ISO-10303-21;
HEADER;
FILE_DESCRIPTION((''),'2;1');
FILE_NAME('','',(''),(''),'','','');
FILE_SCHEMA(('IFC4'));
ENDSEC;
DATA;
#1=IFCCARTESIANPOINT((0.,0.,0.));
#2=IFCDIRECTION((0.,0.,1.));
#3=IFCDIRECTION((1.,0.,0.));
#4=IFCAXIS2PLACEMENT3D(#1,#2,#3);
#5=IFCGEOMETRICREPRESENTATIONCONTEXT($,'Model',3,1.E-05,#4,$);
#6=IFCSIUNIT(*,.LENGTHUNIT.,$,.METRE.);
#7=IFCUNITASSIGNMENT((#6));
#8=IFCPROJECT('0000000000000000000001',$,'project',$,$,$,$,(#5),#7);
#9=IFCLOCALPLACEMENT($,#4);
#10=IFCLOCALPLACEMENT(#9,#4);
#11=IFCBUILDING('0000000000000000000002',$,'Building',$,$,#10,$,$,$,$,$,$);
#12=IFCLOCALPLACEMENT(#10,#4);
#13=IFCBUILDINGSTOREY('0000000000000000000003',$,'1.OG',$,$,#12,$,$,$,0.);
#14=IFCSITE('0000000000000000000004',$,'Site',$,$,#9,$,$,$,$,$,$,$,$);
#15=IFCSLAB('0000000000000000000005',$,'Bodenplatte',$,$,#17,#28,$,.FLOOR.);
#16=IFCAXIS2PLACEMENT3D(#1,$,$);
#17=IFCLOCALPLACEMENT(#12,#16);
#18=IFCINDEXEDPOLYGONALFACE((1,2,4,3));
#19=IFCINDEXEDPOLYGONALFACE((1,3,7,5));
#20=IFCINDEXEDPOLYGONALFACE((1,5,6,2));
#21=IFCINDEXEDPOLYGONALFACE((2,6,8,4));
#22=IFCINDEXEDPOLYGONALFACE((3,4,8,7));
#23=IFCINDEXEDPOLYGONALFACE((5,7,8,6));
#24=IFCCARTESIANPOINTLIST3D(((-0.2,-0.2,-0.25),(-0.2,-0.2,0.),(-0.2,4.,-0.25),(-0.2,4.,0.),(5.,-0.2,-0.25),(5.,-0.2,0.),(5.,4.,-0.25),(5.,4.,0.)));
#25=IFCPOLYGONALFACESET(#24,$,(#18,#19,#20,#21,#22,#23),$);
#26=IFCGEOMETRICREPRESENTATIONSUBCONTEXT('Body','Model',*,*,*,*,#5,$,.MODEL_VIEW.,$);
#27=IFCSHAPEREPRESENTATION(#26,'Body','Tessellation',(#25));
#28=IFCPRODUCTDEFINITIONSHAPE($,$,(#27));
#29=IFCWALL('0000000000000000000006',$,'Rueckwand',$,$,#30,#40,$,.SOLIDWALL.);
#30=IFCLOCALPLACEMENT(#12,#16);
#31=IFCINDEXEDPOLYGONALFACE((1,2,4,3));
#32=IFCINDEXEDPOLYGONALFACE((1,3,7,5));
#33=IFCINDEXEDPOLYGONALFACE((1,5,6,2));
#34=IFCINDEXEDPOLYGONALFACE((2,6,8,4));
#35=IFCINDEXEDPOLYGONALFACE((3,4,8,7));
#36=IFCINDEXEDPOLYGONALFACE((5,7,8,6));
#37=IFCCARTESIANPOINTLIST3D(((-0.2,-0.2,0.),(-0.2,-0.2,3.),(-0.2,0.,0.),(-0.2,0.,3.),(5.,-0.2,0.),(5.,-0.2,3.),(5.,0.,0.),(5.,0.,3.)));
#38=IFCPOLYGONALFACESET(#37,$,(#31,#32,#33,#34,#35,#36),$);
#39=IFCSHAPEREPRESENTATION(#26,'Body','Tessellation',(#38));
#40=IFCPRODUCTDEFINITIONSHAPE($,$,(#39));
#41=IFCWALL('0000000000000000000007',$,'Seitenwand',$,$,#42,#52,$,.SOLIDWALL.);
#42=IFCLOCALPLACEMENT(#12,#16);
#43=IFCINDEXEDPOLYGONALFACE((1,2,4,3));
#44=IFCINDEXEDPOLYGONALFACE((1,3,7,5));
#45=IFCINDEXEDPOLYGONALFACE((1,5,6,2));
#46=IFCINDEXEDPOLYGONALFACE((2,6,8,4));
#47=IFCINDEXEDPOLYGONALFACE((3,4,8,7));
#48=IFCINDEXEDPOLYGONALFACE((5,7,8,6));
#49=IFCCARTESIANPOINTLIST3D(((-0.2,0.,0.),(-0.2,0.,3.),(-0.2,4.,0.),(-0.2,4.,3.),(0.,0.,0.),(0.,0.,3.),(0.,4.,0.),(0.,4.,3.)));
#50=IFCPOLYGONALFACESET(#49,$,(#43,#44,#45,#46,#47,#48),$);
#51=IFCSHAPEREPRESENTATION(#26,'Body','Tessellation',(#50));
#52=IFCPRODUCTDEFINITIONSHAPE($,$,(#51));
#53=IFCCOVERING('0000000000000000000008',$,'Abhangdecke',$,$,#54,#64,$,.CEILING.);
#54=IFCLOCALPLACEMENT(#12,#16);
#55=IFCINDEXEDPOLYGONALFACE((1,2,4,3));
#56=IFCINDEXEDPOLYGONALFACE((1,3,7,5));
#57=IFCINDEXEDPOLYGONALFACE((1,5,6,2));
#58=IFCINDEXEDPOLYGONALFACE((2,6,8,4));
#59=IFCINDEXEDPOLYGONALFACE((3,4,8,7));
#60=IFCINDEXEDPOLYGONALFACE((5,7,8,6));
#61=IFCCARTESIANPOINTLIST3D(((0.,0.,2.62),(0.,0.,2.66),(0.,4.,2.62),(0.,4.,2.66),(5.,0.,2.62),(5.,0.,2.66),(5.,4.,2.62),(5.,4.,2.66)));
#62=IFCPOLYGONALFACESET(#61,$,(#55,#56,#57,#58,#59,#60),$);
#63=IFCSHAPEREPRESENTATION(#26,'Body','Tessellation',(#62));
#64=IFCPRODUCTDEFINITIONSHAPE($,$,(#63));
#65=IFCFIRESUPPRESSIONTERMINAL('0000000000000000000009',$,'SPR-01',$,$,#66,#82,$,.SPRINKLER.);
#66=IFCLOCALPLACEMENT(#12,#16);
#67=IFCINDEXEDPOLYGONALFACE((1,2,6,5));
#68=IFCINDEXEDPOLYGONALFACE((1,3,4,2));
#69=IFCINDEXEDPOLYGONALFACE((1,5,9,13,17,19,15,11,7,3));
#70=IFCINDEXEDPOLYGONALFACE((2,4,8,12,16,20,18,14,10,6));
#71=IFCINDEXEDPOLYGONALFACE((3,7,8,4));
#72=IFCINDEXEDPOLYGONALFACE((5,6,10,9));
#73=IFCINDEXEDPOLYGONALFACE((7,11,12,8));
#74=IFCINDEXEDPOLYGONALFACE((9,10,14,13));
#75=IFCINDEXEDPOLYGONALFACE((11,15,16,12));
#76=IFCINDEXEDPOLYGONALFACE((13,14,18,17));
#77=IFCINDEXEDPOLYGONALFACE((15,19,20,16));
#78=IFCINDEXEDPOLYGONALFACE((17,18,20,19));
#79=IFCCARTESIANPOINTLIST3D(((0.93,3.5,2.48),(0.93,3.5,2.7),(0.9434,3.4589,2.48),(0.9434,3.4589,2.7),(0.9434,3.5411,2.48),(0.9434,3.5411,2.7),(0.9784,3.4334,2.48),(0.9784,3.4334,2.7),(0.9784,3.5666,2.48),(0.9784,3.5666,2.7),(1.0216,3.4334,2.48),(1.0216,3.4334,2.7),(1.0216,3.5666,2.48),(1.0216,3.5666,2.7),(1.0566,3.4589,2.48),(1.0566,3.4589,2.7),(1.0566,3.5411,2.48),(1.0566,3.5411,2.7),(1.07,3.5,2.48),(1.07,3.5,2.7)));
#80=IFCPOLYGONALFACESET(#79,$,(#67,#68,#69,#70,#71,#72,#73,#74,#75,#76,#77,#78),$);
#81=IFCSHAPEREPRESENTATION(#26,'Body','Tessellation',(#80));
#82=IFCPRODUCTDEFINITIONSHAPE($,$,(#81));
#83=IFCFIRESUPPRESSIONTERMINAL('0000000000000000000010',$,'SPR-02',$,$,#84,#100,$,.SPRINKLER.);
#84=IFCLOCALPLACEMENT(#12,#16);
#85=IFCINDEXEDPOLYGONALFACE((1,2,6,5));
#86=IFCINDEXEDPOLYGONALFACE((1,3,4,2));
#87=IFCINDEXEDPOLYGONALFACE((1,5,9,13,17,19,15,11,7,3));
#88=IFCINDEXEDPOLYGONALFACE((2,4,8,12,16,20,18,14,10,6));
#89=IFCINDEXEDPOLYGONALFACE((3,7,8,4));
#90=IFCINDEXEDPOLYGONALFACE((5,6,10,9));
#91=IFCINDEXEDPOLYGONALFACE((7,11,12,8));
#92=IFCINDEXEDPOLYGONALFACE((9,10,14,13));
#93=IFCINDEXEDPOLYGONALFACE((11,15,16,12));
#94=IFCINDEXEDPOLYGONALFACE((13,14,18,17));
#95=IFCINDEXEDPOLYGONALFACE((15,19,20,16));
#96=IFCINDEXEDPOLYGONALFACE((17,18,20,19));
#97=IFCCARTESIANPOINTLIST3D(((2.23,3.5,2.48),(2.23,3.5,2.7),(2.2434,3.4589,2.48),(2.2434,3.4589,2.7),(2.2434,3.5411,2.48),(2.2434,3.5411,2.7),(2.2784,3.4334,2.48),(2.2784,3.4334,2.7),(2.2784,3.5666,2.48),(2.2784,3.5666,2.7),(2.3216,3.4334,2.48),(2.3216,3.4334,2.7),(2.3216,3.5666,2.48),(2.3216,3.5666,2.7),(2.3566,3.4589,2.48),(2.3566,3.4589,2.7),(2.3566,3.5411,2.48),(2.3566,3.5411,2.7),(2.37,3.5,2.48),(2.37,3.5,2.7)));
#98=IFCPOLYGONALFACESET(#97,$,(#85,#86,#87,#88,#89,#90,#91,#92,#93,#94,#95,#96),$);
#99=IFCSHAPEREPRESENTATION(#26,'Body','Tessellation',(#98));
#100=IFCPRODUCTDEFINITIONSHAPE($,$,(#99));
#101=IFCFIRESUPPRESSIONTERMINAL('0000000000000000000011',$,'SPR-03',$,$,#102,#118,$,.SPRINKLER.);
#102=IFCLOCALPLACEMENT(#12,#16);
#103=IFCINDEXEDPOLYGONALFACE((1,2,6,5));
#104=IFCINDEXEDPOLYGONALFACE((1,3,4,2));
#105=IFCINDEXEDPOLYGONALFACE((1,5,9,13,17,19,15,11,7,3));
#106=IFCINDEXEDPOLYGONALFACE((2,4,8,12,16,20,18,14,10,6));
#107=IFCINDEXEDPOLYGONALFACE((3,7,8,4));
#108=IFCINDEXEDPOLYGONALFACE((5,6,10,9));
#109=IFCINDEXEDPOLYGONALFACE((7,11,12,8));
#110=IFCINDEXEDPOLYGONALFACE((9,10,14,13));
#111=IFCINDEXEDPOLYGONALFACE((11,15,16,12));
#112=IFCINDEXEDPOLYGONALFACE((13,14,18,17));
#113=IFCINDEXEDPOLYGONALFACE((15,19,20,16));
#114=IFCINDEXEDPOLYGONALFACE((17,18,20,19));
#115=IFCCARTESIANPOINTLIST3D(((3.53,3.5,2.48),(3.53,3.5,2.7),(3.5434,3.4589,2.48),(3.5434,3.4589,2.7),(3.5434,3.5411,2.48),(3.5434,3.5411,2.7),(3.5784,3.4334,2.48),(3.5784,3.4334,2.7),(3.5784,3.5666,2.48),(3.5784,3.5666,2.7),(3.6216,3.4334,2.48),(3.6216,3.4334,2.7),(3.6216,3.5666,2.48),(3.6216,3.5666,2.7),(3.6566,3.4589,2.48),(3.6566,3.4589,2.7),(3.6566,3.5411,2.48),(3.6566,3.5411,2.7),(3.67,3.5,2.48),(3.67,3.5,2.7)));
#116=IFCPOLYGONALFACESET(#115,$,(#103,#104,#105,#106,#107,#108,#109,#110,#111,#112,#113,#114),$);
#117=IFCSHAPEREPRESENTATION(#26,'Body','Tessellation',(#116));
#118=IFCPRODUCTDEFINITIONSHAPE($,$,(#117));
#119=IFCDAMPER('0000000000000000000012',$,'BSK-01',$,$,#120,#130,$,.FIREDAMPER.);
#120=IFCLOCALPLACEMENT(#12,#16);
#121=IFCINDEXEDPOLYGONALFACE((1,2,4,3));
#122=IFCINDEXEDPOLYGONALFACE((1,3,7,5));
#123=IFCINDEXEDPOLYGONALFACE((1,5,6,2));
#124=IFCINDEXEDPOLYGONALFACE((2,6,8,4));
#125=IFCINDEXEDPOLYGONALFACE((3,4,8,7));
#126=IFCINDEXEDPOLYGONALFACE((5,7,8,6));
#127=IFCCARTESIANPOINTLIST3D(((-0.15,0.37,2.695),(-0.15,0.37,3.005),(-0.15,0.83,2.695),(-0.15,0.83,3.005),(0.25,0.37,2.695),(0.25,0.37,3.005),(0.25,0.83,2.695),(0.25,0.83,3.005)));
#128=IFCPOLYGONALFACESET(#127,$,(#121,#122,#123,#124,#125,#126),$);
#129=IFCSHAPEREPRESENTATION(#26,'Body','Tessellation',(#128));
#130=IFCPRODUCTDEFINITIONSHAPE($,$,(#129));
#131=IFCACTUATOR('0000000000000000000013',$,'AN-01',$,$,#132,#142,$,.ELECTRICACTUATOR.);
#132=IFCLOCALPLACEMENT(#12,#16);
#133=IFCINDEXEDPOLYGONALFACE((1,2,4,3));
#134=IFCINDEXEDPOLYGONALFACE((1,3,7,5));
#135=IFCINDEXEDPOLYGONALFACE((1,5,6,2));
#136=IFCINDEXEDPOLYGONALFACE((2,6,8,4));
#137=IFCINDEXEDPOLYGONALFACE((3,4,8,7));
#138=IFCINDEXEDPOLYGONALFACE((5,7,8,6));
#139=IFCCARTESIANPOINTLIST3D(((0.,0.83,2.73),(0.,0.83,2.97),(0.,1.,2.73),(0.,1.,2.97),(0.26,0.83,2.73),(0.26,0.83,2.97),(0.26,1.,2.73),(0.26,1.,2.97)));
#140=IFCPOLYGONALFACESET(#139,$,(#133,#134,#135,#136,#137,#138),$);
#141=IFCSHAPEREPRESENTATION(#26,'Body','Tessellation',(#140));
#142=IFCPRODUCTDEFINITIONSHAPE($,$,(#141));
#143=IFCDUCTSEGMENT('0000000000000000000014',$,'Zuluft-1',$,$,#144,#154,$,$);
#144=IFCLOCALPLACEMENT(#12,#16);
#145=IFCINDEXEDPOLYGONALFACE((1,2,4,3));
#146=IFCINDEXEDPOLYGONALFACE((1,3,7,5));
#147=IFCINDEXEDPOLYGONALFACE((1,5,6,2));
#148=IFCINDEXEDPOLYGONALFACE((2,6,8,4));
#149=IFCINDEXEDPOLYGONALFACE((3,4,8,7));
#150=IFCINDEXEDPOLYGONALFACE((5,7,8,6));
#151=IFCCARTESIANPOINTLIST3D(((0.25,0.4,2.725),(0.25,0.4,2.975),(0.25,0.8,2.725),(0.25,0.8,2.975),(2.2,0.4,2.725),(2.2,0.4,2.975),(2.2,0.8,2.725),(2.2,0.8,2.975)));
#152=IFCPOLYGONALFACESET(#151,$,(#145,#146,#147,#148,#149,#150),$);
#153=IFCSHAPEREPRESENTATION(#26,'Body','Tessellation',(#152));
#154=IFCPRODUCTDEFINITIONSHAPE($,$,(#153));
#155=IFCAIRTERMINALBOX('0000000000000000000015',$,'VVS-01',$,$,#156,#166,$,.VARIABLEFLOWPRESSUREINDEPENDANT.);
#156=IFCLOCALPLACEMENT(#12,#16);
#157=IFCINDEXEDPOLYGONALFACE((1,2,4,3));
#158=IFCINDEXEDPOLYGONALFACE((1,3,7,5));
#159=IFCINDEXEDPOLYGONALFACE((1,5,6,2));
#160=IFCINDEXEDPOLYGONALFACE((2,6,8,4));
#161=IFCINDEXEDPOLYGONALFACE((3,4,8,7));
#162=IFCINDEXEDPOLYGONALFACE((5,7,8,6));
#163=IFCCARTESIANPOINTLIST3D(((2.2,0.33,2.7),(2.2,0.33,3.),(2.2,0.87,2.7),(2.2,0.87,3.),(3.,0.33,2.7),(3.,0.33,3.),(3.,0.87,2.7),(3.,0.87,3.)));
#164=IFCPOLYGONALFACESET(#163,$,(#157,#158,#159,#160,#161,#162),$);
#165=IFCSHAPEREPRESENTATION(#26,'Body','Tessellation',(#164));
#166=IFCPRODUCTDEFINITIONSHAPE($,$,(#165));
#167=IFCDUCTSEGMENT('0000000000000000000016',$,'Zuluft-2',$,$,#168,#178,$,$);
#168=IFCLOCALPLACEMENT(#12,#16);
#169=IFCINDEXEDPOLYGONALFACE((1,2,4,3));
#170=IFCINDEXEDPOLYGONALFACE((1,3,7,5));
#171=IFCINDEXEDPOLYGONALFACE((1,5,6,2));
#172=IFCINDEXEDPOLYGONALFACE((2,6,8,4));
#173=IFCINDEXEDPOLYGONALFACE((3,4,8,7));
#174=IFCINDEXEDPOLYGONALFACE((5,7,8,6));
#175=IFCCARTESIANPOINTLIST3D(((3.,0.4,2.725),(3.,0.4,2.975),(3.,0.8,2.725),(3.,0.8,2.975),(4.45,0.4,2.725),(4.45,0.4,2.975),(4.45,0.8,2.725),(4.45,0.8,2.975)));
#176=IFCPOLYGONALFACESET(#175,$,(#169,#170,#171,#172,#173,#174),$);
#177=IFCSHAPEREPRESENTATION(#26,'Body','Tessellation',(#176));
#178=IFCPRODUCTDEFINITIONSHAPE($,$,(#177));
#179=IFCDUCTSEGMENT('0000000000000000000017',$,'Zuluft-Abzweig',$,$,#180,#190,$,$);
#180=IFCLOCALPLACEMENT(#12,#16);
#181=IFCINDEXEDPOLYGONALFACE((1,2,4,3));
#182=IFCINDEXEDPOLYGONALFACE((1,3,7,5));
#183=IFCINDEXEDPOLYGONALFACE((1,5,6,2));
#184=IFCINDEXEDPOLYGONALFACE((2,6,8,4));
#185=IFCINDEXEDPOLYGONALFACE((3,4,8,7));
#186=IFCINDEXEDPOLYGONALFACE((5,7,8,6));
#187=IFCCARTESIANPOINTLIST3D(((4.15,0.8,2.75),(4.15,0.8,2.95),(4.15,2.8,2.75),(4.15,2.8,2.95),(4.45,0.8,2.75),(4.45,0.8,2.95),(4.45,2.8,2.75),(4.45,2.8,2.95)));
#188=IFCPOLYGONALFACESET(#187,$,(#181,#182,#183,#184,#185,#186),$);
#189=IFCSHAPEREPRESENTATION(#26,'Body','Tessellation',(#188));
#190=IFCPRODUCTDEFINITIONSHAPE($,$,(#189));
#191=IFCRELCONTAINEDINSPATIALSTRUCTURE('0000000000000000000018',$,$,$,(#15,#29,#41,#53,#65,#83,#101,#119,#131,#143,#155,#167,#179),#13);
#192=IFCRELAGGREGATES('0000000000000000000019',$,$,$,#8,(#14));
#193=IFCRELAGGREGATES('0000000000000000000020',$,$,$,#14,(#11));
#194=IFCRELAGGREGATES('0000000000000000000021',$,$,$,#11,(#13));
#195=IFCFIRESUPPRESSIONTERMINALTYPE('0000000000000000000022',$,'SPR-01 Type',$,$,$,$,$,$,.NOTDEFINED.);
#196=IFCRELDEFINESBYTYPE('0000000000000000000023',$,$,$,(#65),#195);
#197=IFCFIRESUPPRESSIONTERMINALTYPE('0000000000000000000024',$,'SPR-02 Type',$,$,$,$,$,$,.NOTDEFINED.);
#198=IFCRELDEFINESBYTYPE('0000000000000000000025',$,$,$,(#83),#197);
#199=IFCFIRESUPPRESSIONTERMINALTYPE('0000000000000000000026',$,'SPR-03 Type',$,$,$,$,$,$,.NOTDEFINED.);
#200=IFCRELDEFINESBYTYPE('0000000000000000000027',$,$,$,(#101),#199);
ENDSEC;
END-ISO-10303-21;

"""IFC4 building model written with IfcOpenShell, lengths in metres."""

from ifc_helpers import new_model, si_unit, frame, origin_with_axes, place, context, subcontext, project, spatial, polyline, outline, extrude, type_object, element, save


model = new_model("IFC4")

# Units and contexts
model_context = context("Model", 3, precision=1e-05, world=origin_with_axes())
body_context = subcontext(model_context, "Body", "Model", "MODEL_VIEW")
ifc_project = project(units=[si_unit("LENGTHUNIT", "METRE")], contexts=[model_context])

# Site, building, storey
site_placement = place(None, origin_with_axes())
site = spatial("IfcSite", under=ifc_project, at=site_placement, Name="Site")
building_placement = place(site_placement, origin_with_axes())
building = spatial("IfcBuilding", under=site, at=building_placement, Name="Building")
storey_placement = place(building_placement, origin_with_axes())
storey = spatial("IfcBuildingStorey", under=building, at=storey_placement, Name="1.OG", Elevation=0.0)

# Slab
slab_placement = place(storey_placement, frame((0.0, 0.0, -0.25), z_axis=(0.0, 0.0, 1.0), x_axis=(1.0, 0.0, 0.0)))
element("IfcSlab", 1, at=slab_placement, inside=storey, Name="Bodenplatte", PredefinedType="FLOOR", context=body_context, shape_type="SweptSolid", body=[
    extrude(outline(polyline([(-0.2, -0.2, 0.0), (5.0, -0.2, 0.0), (5.0, 4.0, 0.0), (-0.2, 4.0, 0.0), (-0.2, -0.2, 0.0)])), origin_with_axes(), (0.0, 0.0, 1.0), 0.25),
])

# Walls
wall_1_placement = place(storey_placement, frame((-0.2, -0.2, 0.0), z_axis=(0.0, 0.0, 1.0), x_axis=(1.0, 0.0, 0.0)))
element("IfcWall", 2, at=wall_1_placement, inside=storey, Name="Rueckwand", PredefinedType="SOLIDWALL", context=body_context, shape_type="SweptSolid", body=[
    extrude(outline(polyline([(0.0, 0.0, 0.0), (5.2, 0.0, 0.0), (5.2, 0.2, 0.0), (0.0, 0.2, 0.0), (0.0, 0.0, 0.0)])), origin_with_axes(), (0.0, 0.0, 1.0), 3.0),
])
wall_2_placement = place(storey_placement, frame((0.0, 0.0, 0.0), z_axis=(0.0, 0.0, 1.0), x_axis=(0.0, 1.0, 0.0)))
element("IfcWall", 3, at=wall_2_placement, inside=storey, Name="Seitenwand", PredefinedType="SOLIDWALL", context=body_context, shape_type="SweptSolid", body=[
    extrude(outline(polyline([(0.0, 0.0, 0.0), (4.0, 0.0, 0.0), (4.0, 0.2, 0.0), (0.0, 0.2, 0.0), (0.0, 0.0, 0.0)])), origin_with_axes(), (0.0, 0.0, 1.0), 3.0),
])

# Covering
covering_placement = place(storey_placement, frame((0.0, 0.0, 2.62), z_axis=(0.0, 0.0, 1.0), x_axis=(1.0, 0.0, 0.0)))
element("IfcCovering", 4, at=covering_placement, inside=storey, Name="Abhangdecke", PredefinedType="CEILING", context=body_context, shape_type="SweptSolid", body=[
    extrude(outline(polyline([(0.0, 0.0, 0.0), (5.0, 0.0, 0.0), (5.0, 4.0, 0.0), (0.0, 4.0, 0.0), (0.0, 0.0, 0.0)])), origin_with_axes(), (0.0, 0.0, 1.0), 0.04),
])

# Fire suppression terminals
fire_suppression_terminal_type_1 = type_object("IfcFireSuppressionTerminalType", Name="SPR-01 Type", PredefinedType="NOTDEFINED")
fire_suppression_terminal_1_placement = place(storey_placement, origin_with_axes())
element("IfcFireSuppressionTerminal", 5, at=fire_suppression_terminal_1_placement, inside=storey, type_object=fire_suppression_terminal_type_1, Name="SPR-01", PredefinedType="SPRINKLER", context=body_context, shape_type="SweptSolid", body=[
    extrude(outline(polyline([(0.07, 0.0, 0.0), (0.0566, 0.0411, 0.0), (0.0216, 0.0666, 0.0), (-0.0216, 0.0666, 0.0), (-0.0566, 0.0411, 0.0), (-0.07, 0.0, 0.0), (-0.0566, -0.0411, 0.0), (-0.0216, -0.0666, 0.0), (0.0216, -0.0666, 0.0), (0.0566, -0.0411, 0.0), (0.07, 0.0, 0.0)])), frame((1.0, 3.5, 2.48), z_axis=(0.0, 0.0, 1.0), x_axis=(1.0, 0.0, 0.0)), (0.0, 0.0, 1.0), 0.22),
])
fire_suppression_terminal_type_2 = type_object("IfcFireSuppressionTerminalType", Name="SPR-02 Type", PredefinedType="NOTDEFINED")
fire_suppression_terminal_2_placement = place(storey_placement, origin_with_axes())
element("IfcFireSuppressionTerminal", 6, at=fire_suppression_terminal_2_placement, inside=storey, type_object=fire_suppression_terminal_type_2, Name="SPR-02", PredefinedType="SPRINKLER", context=body_context, shape_type="SweptSolid", body=[
    extrude(outline(polyline([(0.07, 0.0, 0.0), (0.0566, 0.0411, 0.0), (0.0216, 0.0666, 0.0), (-0.0216, 0.0666, 0.0), (-0.0566, 0.0411, 0.0), (-0.07, 0.0, 0.0), (-0.0566, -0.0411, 0.0), (-0.0216, -0.0666, 0.0), (0.0216, -0.0666, 0.0), (0.0566, -0.0411, 0.0), (0.07, 0.0, 0.0)])), frame((2.3, 3.5, 2.48), z_axis=(0.0, 0.0, 1.0), x_axis=(1.0, 0.0, 0.0)), (0.0, 0.0, 1.0), 0.22),
])
fire_suppression_terminal_type_3 = type_object("IfcFireSuppressionTerminalType", Name="SPR-03 Type", PredefinedType="NOTDEFINED")
fire_suppression_terminal_3_placement = place(storey_placement, origin_with_axes())
element("IfcFireSuppressionTerminal", 7, at=fire_suppression_terminal_3_placement, inside=storey, type_object=fire_suppression_terminal_type_3, Name="SPR-03", PredefinedType="SPRINKLER", context=body_context, shape_type="SweptSolid", body=[
    extrude(outline(polyline([(0.07, 0.0, 0.0), (0.0566, 0.0411, 0.0), (0.0216, 0.0666, 0.0), (-0.0216, 0.0666, 0.0), (-0.0566, 0.0411, 0.0), (-0.07, 0.0, 0.0), (-0.0566, -0.0411, 0.0), (-0.0216, -0.0666, 0.0), (0.0216, -0.0666, 0.0), (0.0566, -0.0411, 0.0), (0.07, 0.0, 0.0)])), frame((3.6, 3.5, 2.48), z_axis=(0.0, 0.0, 1.0), x_axis=(1.0, 0.0, 0.0)), (0.0, 0.0, 1.0), 0.22),
])

# Damper
damper_placement = place(storey_placement, origin_with_axes())
element("IfcDamper", 8, at=damper_placement, inside=storey, Name="BSK-01", PredefinedType="FIREDAMPER", context=body_context, shape_type="SweptSolid", body=[
    extrude(outline(polyline([(-0.15, 0.37, 0.0), (0.25, 0.37, 0.0), (0.25, 0.83, 0.0), (-0.15, 0.83, 0.0), (-0.15, 0.37, 0.0)])), frame((0.0, 0.0, 2.695), z_axis=(0.0, 0.0, 1.0), x_axis=(1.0, 0.0, 0.0)), (0.0, 0.0, 1.0), 0.31),
])

# Actuator
actuator_placement = place(storey_placement, origin_with_axes())
element("IfcActuator", 9, at=actuator_placement, inside=storey, Name="AN-01", PredefinedType="ELECTRICACTUATOR", context=body_context, shape_type="SweptSolid", body=[
    extrude(outline(polyline([(0.0, 0.83, 0.0), (0.26, 0.83, 0.0), (0.26, 1.0, 0.0), (0.0, 1.0, 0.0), (0.0, 0.83, 0.0)])), frame((0.0, 0.0, 2.73), z_axis=(0.0, 0.0, 1.0), x_axis=(1.0, 0.0, 0.0)), (0.0, 0.0, 1.0), 0.24),
])

# Duct segment
duct_segment_1_placement = place(storey_placement, origin_with_axes())
element("IfcDuctSegment", 10, at=duct_segment_1_placement, inside=storey, Name="Zuluft-1", context=body_context, shape_type="SweptSolid", body=[
    extrude(outline(polyline([(-0.2, -0.125, 0.0), (0.2, -0.125, 0.0), (0.2, 0.125, 0.0), (-0.2, 0.125, 0.0), (-0.2, -0.125, 0.0)])), frame((0.25, 0.6, 2.85), z_axis=(1.0, 0.0, 0.0), x_axis=(0.0, 1.0, 0.0)), (0.0, 0.0, 1.0), 1.95),
])

# Air terminal box
air_terminal_box_placement = place(storey_placement, origin_with_axes())
element("IfcAirTerminalBox", 11, at=air_terminal_box_placement, inside=storey, Name="VVS-01", PredefinedType="VARIABLEFLOWPRESSUREINDEPENDANT", context=body_context, shape_type="SweptSolid", body=[
    extrude(outline(polyline([(2.2, 0.33, 0.0), (3.0, 0.33, 0.0), (3.0, 0.87, 0.0), (2.2, 0.87, 0.0), (2.2, 0.33, 0.0)])), frame((0.0, 0.0, 2.7), z_axis=(0.0, 0.0, 1.0), x_axis=(1.0, 0.0, 0.0)), (0.0, 0.0, 1.0), 0.3),
])

# Duct segments
duct_segment_2_placement = place(storey_placement, origin_with_axes())
element("IfcDuctSegment", 12, at=duct_segment_2_placement, inside=storey, Name="Zuluft-2", context=body_context, shape_type="SweptSolid", body=[
    extrude(outline(polyline([(-0.2, -0.125, 0.0), (0.2, -0.125, 0.0), (0.2, 0.125, 0.0), (-0.2, 0.125, 0.0), (-0.2, -0.125, 0.0)])), frame((3.0, 0.6, 2.85), z_axis=(1.0, 0.0, 0.0), x_axis=(0.0, 1.0, 0.0)), (0.0, 0.0, 1.0), 1.45),
])
duct_segment_3_placement = place(storey_placement, origin_with_axes())
element("IfcDuctSegment", 13, at=duct_segment_3_placement, inside=storey, Name="Zuluft-Abzweig", context=body_context, shape_type="SweptSolid", body=[
    extrude(outline(polyline([(-0.15, -0.1, 0.0), (0.15, -0.1, 0.0), (0.15, 0.1, 0.0), (-0.15, 0.1, 0.0), (-0.15, -0.1, 0.0)])), frame((4.3, 0.8, 2.85), z_axis=(0.0, 1.0, 0.0), x_axis=(-1.0, 0.0, 0.0)), (0.0, 0.0, 1.0), 2.0),
])

save(model, "model.ifc")
